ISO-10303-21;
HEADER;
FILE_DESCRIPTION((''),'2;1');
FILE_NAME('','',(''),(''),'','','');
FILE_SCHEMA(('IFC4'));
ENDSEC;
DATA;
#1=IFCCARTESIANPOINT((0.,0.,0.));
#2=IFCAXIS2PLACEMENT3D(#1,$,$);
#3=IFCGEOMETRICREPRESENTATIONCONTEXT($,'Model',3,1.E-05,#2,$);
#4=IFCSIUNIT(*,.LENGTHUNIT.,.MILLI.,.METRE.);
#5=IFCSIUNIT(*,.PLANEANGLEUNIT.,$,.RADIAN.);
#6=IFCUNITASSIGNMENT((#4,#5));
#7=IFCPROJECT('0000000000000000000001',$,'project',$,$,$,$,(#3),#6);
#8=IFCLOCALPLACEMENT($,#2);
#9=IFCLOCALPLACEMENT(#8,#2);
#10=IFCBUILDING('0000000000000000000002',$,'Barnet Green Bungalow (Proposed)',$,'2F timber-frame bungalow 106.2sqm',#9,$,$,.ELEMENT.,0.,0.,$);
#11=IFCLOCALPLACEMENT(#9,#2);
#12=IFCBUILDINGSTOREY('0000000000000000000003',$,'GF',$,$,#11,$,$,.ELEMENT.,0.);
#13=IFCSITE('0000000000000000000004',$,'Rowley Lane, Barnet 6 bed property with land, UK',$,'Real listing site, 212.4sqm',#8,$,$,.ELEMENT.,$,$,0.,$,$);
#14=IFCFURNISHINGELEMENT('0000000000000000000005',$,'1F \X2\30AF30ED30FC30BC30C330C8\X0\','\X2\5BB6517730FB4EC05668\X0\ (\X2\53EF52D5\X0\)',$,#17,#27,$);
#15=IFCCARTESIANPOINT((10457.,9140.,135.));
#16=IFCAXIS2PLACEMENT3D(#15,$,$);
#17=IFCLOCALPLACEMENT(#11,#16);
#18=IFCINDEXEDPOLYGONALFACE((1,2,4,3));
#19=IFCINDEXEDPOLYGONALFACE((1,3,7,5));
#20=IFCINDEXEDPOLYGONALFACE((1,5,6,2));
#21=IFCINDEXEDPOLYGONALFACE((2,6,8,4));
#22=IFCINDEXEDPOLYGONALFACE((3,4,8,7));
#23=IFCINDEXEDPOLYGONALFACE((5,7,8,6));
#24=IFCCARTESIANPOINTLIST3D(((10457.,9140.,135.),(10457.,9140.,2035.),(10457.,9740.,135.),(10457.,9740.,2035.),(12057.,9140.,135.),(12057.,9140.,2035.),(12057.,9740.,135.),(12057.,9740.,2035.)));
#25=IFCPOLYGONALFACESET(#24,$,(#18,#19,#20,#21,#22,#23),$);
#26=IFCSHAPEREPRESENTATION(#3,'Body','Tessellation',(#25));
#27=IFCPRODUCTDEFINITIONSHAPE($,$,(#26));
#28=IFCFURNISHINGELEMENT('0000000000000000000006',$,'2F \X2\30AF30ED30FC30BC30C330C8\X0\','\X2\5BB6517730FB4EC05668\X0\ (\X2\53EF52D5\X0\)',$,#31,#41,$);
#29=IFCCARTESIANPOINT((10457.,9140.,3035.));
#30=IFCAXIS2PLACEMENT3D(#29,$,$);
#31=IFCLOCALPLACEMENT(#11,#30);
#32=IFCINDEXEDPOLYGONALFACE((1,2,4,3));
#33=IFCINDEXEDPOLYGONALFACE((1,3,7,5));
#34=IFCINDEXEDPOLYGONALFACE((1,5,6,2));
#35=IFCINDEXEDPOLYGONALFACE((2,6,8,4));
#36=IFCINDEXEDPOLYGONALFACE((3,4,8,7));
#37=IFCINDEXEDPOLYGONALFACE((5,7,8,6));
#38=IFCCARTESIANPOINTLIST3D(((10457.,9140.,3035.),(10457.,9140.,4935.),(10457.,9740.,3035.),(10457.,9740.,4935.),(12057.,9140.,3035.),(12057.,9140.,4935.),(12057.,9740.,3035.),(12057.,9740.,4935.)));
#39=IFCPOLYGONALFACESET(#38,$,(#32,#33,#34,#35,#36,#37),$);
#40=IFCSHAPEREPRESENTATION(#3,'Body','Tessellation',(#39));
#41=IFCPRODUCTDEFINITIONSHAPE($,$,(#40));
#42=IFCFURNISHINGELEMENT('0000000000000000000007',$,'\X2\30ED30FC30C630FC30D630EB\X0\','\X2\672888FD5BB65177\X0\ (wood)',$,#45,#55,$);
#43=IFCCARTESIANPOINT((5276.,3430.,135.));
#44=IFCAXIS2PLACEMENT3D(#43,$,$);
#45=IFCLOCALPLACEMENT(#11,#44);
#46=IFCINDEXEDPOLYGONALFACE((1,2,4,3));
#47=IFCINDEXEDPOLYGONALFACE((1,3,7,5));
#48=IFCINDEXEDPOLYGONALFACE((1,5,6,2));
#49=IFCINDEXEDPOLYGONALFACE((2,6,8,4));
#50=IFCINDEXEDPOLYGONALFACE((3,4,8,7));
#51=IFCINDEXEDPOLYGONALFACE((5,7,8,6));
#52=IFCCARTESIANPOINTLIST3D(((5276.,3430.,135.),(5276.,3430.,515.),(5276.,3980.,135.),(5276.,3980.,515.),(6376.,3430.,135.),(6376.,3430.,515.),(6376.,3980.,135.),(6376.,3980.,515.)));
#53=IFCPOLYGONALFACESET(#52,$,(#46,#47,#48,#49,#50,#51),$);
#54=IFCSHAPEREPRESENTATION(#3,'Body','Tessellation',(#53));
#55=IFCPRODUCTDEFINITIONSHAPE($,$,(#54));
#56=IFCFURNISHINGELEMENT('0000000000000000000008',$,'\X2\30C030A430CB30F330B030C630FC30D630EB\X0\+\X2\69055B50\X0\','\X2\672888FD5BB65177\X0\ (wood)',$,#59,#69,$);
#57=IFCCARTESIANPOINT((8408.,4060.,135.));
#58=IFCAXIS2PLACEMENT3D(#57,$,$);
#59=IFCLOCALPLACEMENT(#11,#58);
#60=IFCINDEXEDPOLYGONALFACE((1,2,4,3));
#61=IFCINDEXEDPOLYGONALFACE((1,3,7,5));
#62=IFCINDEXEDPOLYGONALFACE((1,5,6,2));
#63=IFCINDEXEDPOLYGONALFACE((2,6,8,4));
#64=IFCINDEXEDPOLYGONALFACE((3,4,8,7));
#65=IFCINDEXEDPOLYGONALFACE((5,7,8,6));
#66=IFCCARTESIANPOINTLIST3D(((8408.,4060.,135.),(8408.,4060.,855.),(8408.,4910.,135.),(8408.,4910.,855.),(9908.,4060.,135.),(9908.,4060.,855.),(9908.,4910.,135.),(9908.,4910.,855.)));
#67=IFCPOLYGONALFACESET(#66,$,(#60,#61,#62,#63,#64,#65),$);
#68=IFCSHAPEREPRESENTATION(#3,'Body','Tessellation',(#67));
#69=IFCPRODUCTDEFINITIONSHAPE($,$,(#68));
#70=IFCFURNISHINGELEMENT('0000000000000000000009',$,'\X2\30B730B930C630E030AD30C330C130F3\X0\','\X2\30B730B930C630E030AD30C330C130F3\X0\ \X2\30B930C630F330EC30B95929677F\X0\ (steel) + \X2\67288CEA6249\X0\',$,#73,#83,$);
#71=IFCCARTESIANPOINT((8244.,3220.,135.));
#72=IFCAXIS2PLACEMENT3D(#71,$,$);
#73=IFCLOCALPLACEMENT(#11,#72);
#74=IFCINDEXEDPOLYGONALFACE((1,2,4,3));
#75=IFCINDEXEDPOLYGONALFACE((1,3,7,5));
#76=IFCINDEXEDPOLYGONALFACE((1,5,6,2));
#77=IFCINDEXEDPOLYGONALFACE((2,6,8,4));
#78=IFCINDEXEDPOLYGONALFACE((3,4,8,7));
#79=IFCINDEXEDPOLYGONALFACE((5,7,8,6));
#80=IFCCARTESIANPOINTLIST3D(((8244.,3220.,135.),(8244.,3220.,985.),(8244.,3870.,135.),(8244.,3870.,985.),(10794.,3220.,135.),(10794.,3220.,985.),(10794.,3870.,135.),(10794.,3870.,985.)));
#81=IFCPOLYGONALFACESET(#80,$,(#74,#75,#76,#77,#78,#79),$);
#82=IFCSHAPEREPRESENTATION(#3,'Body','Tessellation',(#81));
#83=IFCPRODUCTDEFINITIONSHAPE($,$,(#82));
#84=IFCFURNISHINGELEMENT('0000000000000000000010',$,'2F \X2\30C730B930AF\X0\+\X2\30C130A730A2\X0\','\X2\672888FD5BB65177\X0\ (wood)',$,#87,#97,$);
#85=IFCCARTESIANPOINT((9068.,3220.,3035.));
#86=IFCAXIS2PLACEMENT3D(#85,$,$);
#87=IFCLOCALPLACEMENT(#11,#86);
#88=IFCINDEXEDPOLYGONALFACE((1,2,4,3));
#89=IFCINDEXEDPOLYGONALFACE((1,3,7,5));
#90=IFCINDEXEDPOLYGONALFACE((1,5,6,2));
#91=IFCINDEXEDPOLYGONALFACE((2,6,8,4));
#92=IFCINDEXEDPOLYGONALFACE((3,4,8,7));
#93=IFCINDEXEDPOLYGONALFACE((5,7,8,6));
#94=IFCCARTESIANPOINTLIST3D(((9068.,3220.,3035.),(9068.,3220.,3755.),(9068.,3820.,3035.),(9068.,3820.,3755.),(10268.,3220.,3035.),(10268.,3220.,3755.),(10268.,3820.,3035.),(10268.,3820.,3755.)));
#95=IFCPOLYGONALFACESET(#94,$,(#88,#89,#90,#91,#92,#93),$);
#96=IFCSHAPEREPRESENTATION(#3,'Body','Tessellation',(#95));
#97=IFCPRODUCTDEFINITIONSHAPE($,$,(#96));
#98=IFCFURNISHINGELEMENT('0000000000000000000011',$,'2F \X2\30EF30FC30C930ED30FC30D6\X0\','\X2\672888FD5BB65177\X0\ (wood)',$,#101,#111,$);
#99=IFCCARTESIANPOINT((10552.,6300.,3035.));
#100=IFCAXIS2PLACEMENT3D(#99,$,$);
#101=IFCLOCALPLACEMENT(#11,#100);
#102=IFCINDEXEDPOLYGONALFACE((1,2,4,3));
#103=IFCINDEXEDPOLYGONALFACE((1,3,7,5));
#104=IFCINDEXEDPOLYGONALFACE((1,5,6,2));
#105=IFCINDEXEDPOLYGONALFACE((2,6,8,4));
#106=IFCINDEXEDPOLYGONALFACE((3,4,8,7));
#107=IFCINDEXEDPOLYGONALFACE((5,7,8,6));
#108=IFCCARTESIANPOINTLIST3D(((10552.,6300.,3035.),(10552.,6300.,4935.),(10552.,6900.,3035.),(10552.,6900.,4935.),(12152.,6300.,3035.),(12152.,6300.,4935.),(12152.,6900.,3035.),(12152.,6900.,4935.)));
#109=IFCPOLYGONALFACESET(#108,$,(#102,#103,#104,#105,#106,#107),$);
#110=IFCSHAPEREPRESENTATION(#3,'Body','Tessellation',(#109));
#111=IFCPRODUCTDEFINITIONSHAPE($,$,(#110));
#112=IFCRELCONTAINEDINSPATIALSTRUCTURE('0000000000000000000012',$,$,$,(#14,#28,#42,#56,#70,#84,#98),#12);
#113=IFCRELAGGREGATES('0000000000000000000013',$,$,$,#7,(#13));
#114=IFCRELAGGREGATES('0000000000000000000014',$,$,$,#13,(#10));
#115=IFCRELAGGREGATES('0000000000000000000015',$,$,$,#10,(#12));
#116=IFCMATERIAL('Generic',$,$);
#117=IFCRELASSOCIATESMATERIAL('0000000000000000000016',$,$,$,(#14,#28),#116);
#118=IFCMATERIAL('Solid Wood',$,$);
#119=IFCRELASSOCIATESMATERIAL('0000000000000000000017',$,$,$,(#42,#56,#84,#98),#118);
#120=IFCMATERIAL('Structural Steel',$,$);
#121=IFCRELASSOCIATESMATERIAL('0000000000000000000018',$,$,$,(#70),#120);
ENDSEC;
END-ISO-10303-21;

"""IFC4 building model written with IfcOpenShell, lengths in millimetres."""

from ifc_helpers import new_model, si_unit, frame, frame_2d, origin, place, context, project, spatial, rectangle, extrude, material, element, save


model = new_model("IFC4")

# Units and contexts
model_context = context("Model", 3, precision=1e-05, world=origin())
ifc_project = project(units=[si_unit("LENGTHUNIT", "METRE", prefix="MILLI"), si_unit("PLANEANGLEUNIT", "RADIAN")], contexts=[model_context])

# Site, building, storey
site_placement = place(None, origin())
site = spatial("IfcSite", under=ifc_project, at=site_placement, Name="Rowley Lane, Barnet 6 bed property with land, UK", ObjectType="Real listing site, 212.4sqm", CompositionType="ELEMENT", RefElevation=0.0)
building_placement = place(site_placement, origin())
building = spatial("IfcBuilding", under=site, at=building_placement, Name="Barnet Green Bungalow (Proposed)", ObjectType="2F timber-frame bungalow 106.2sqm", CompositionType="ELEMENT", ElevationOfRefHeight=0.0, ElevationOfTerrain=0.0)
storey_placement = place(building_placement, origin())
storey = spatial("IfcBuildingStorey", under=building, at=storey_placement, Name="GF", CompositionType="ELEMENT", Elevation=0.0)

# Shared definitions
ifc_material_1 = material(Name="Solid Wood")

# Shared definitions
ifc_material_2 = material(Name="Generic")

# Furnishing elements
furnishing_1_placement = place(storey_placement, frame((10457.0, 9140.0, 135.0)))
element("IfcFurnishingElement", 1, at=furnishing_1_placement, inside=storey, material=ifc_material_2, Name="1F クローゼット", Description="家具・什器 (可動)", context=model_context, shape_type="SweptSolid", body=[
    extrude(rectangle(XDim=1600.0, YDim=600.0, at=frame_2d((800.0, 300.0))), frame((10457.0, 9140.0, 135.0)), (0.0, 0.0, 1.0), 1900.0),
])
furnishing_2_placement = place(storey_placement, frame((10457.0, 9140.0, 3035.0)))
element("IfcFurnishingElement", 2, at=furnishing_2_placement, inside=storey, material=ifc_material_2, Name="2F クローゼット", Description="家具・什器 (可動)", context=model_context, shape_type="SweptSolid", body=[
    extrude(rectangle(XDim=1600.0, YDim=600.0, at=frame_2d((800.0, 300.0))), frame((10457.0, 9140.0, 3035.0)), (0.0, 0.0, 1.0), 1900.0),
])
furnishing_3_placement = place(storey_placement, frame((5276.0, 3430.0, 135.0)))
element("IfcFurnishingElement", 3, at=furnishing_3_placement, inside=storey, material=ifc_material_1, Name="ローテーブル", Description="木製家具 (wood)", context=model_context, shape_type="SweptSolid", body=[
    extrude(rectangle(XDim=1100.0, YDim=550.0, at=frame_2d((550.0, 275.0))), frame((5276.0, 3430.0, 135.0)), (0.0, 0.0, 1.0), 380.0),
])
furnishing_4_placement = place(storey_placement, frame((8408.0, 4060.0, 135.0)))
element("IfcFurnishingElement", 4, at=furnishing_4_placement, inside=storey, material=ifc_material_1, Name="ダイニングテーブル+椅子", Description="木製家具 (wood)", context=model_context, shape_type="SweptSolid", body=[
    extrude(rectangle(XDim=1500.0, YDim=850.0, at=frame_2d((750.0, 425.0))), frame((8408.0, 4060.0, 135.0)), (0.0, 0.0, 1.0), 720.0),
])
ifc_material_3 = material(Name="Structural Steel")
furnishing_5_placement = place(storey_placement, frame((8244.0, 3220.0, 135.0)))
element("IfcFurnishingElement", 5, at=furnishing_5_placement, inside=storey, material=ifc_material_3, Name="システムキッチン", Description="システムキッチン ステンレス天板 (steel) + 木質扉", context=model_context, shape_type="SweptSolid", body=[
    extrude(rectangle(XDim=2550.0, YDim=650.0, at=frame_2d((1275.0, 325.0))), frame((8244.0, 3220.0, 135.0)), (0.0, 0.0, 1.0), 850.0),
])
furnishing_6_placement = place(storey_placement, frame((9068.0, 3220.0, 3035.0)))
element("IfcFurnishingElement", 6, at=furnishing_6_placement, inside=storey, material=ifc_material_1, Name="2F デスク+チェア", Description="木製家具 (wood)", context=model_context, shape_type="SweptSolid", body=[
    extrude(rectangle(XDim=1200.0, YDim=600.0, at=frame_2d((600.0, 300.0))), frame((9068.0, 3220.0, 3035.0)), (0.0, 0.0, 1.0), 720.0),
])
furnishing_7_placement = place(storey_placement, frame((10552.0, 6300.0, 3035.0)))
element("IfcFurnishingElement", 7, at=furnishing_7_placement, inside=storey, material=ifc_material_1, Name="2F ワードローブ", Description="木製家具 (wood)", context=model_context, shape_type="SweptSolid", body=[
    extrude(rectangle(XDim=1600.0, YDim=600.0, at=frame_2d((800.0, 300.0))), frame((10552.0, 6300.0, 3035.0)), (0.0, 0.0, 1.0), 1900.0),
])

save(model, "model.ifc")
